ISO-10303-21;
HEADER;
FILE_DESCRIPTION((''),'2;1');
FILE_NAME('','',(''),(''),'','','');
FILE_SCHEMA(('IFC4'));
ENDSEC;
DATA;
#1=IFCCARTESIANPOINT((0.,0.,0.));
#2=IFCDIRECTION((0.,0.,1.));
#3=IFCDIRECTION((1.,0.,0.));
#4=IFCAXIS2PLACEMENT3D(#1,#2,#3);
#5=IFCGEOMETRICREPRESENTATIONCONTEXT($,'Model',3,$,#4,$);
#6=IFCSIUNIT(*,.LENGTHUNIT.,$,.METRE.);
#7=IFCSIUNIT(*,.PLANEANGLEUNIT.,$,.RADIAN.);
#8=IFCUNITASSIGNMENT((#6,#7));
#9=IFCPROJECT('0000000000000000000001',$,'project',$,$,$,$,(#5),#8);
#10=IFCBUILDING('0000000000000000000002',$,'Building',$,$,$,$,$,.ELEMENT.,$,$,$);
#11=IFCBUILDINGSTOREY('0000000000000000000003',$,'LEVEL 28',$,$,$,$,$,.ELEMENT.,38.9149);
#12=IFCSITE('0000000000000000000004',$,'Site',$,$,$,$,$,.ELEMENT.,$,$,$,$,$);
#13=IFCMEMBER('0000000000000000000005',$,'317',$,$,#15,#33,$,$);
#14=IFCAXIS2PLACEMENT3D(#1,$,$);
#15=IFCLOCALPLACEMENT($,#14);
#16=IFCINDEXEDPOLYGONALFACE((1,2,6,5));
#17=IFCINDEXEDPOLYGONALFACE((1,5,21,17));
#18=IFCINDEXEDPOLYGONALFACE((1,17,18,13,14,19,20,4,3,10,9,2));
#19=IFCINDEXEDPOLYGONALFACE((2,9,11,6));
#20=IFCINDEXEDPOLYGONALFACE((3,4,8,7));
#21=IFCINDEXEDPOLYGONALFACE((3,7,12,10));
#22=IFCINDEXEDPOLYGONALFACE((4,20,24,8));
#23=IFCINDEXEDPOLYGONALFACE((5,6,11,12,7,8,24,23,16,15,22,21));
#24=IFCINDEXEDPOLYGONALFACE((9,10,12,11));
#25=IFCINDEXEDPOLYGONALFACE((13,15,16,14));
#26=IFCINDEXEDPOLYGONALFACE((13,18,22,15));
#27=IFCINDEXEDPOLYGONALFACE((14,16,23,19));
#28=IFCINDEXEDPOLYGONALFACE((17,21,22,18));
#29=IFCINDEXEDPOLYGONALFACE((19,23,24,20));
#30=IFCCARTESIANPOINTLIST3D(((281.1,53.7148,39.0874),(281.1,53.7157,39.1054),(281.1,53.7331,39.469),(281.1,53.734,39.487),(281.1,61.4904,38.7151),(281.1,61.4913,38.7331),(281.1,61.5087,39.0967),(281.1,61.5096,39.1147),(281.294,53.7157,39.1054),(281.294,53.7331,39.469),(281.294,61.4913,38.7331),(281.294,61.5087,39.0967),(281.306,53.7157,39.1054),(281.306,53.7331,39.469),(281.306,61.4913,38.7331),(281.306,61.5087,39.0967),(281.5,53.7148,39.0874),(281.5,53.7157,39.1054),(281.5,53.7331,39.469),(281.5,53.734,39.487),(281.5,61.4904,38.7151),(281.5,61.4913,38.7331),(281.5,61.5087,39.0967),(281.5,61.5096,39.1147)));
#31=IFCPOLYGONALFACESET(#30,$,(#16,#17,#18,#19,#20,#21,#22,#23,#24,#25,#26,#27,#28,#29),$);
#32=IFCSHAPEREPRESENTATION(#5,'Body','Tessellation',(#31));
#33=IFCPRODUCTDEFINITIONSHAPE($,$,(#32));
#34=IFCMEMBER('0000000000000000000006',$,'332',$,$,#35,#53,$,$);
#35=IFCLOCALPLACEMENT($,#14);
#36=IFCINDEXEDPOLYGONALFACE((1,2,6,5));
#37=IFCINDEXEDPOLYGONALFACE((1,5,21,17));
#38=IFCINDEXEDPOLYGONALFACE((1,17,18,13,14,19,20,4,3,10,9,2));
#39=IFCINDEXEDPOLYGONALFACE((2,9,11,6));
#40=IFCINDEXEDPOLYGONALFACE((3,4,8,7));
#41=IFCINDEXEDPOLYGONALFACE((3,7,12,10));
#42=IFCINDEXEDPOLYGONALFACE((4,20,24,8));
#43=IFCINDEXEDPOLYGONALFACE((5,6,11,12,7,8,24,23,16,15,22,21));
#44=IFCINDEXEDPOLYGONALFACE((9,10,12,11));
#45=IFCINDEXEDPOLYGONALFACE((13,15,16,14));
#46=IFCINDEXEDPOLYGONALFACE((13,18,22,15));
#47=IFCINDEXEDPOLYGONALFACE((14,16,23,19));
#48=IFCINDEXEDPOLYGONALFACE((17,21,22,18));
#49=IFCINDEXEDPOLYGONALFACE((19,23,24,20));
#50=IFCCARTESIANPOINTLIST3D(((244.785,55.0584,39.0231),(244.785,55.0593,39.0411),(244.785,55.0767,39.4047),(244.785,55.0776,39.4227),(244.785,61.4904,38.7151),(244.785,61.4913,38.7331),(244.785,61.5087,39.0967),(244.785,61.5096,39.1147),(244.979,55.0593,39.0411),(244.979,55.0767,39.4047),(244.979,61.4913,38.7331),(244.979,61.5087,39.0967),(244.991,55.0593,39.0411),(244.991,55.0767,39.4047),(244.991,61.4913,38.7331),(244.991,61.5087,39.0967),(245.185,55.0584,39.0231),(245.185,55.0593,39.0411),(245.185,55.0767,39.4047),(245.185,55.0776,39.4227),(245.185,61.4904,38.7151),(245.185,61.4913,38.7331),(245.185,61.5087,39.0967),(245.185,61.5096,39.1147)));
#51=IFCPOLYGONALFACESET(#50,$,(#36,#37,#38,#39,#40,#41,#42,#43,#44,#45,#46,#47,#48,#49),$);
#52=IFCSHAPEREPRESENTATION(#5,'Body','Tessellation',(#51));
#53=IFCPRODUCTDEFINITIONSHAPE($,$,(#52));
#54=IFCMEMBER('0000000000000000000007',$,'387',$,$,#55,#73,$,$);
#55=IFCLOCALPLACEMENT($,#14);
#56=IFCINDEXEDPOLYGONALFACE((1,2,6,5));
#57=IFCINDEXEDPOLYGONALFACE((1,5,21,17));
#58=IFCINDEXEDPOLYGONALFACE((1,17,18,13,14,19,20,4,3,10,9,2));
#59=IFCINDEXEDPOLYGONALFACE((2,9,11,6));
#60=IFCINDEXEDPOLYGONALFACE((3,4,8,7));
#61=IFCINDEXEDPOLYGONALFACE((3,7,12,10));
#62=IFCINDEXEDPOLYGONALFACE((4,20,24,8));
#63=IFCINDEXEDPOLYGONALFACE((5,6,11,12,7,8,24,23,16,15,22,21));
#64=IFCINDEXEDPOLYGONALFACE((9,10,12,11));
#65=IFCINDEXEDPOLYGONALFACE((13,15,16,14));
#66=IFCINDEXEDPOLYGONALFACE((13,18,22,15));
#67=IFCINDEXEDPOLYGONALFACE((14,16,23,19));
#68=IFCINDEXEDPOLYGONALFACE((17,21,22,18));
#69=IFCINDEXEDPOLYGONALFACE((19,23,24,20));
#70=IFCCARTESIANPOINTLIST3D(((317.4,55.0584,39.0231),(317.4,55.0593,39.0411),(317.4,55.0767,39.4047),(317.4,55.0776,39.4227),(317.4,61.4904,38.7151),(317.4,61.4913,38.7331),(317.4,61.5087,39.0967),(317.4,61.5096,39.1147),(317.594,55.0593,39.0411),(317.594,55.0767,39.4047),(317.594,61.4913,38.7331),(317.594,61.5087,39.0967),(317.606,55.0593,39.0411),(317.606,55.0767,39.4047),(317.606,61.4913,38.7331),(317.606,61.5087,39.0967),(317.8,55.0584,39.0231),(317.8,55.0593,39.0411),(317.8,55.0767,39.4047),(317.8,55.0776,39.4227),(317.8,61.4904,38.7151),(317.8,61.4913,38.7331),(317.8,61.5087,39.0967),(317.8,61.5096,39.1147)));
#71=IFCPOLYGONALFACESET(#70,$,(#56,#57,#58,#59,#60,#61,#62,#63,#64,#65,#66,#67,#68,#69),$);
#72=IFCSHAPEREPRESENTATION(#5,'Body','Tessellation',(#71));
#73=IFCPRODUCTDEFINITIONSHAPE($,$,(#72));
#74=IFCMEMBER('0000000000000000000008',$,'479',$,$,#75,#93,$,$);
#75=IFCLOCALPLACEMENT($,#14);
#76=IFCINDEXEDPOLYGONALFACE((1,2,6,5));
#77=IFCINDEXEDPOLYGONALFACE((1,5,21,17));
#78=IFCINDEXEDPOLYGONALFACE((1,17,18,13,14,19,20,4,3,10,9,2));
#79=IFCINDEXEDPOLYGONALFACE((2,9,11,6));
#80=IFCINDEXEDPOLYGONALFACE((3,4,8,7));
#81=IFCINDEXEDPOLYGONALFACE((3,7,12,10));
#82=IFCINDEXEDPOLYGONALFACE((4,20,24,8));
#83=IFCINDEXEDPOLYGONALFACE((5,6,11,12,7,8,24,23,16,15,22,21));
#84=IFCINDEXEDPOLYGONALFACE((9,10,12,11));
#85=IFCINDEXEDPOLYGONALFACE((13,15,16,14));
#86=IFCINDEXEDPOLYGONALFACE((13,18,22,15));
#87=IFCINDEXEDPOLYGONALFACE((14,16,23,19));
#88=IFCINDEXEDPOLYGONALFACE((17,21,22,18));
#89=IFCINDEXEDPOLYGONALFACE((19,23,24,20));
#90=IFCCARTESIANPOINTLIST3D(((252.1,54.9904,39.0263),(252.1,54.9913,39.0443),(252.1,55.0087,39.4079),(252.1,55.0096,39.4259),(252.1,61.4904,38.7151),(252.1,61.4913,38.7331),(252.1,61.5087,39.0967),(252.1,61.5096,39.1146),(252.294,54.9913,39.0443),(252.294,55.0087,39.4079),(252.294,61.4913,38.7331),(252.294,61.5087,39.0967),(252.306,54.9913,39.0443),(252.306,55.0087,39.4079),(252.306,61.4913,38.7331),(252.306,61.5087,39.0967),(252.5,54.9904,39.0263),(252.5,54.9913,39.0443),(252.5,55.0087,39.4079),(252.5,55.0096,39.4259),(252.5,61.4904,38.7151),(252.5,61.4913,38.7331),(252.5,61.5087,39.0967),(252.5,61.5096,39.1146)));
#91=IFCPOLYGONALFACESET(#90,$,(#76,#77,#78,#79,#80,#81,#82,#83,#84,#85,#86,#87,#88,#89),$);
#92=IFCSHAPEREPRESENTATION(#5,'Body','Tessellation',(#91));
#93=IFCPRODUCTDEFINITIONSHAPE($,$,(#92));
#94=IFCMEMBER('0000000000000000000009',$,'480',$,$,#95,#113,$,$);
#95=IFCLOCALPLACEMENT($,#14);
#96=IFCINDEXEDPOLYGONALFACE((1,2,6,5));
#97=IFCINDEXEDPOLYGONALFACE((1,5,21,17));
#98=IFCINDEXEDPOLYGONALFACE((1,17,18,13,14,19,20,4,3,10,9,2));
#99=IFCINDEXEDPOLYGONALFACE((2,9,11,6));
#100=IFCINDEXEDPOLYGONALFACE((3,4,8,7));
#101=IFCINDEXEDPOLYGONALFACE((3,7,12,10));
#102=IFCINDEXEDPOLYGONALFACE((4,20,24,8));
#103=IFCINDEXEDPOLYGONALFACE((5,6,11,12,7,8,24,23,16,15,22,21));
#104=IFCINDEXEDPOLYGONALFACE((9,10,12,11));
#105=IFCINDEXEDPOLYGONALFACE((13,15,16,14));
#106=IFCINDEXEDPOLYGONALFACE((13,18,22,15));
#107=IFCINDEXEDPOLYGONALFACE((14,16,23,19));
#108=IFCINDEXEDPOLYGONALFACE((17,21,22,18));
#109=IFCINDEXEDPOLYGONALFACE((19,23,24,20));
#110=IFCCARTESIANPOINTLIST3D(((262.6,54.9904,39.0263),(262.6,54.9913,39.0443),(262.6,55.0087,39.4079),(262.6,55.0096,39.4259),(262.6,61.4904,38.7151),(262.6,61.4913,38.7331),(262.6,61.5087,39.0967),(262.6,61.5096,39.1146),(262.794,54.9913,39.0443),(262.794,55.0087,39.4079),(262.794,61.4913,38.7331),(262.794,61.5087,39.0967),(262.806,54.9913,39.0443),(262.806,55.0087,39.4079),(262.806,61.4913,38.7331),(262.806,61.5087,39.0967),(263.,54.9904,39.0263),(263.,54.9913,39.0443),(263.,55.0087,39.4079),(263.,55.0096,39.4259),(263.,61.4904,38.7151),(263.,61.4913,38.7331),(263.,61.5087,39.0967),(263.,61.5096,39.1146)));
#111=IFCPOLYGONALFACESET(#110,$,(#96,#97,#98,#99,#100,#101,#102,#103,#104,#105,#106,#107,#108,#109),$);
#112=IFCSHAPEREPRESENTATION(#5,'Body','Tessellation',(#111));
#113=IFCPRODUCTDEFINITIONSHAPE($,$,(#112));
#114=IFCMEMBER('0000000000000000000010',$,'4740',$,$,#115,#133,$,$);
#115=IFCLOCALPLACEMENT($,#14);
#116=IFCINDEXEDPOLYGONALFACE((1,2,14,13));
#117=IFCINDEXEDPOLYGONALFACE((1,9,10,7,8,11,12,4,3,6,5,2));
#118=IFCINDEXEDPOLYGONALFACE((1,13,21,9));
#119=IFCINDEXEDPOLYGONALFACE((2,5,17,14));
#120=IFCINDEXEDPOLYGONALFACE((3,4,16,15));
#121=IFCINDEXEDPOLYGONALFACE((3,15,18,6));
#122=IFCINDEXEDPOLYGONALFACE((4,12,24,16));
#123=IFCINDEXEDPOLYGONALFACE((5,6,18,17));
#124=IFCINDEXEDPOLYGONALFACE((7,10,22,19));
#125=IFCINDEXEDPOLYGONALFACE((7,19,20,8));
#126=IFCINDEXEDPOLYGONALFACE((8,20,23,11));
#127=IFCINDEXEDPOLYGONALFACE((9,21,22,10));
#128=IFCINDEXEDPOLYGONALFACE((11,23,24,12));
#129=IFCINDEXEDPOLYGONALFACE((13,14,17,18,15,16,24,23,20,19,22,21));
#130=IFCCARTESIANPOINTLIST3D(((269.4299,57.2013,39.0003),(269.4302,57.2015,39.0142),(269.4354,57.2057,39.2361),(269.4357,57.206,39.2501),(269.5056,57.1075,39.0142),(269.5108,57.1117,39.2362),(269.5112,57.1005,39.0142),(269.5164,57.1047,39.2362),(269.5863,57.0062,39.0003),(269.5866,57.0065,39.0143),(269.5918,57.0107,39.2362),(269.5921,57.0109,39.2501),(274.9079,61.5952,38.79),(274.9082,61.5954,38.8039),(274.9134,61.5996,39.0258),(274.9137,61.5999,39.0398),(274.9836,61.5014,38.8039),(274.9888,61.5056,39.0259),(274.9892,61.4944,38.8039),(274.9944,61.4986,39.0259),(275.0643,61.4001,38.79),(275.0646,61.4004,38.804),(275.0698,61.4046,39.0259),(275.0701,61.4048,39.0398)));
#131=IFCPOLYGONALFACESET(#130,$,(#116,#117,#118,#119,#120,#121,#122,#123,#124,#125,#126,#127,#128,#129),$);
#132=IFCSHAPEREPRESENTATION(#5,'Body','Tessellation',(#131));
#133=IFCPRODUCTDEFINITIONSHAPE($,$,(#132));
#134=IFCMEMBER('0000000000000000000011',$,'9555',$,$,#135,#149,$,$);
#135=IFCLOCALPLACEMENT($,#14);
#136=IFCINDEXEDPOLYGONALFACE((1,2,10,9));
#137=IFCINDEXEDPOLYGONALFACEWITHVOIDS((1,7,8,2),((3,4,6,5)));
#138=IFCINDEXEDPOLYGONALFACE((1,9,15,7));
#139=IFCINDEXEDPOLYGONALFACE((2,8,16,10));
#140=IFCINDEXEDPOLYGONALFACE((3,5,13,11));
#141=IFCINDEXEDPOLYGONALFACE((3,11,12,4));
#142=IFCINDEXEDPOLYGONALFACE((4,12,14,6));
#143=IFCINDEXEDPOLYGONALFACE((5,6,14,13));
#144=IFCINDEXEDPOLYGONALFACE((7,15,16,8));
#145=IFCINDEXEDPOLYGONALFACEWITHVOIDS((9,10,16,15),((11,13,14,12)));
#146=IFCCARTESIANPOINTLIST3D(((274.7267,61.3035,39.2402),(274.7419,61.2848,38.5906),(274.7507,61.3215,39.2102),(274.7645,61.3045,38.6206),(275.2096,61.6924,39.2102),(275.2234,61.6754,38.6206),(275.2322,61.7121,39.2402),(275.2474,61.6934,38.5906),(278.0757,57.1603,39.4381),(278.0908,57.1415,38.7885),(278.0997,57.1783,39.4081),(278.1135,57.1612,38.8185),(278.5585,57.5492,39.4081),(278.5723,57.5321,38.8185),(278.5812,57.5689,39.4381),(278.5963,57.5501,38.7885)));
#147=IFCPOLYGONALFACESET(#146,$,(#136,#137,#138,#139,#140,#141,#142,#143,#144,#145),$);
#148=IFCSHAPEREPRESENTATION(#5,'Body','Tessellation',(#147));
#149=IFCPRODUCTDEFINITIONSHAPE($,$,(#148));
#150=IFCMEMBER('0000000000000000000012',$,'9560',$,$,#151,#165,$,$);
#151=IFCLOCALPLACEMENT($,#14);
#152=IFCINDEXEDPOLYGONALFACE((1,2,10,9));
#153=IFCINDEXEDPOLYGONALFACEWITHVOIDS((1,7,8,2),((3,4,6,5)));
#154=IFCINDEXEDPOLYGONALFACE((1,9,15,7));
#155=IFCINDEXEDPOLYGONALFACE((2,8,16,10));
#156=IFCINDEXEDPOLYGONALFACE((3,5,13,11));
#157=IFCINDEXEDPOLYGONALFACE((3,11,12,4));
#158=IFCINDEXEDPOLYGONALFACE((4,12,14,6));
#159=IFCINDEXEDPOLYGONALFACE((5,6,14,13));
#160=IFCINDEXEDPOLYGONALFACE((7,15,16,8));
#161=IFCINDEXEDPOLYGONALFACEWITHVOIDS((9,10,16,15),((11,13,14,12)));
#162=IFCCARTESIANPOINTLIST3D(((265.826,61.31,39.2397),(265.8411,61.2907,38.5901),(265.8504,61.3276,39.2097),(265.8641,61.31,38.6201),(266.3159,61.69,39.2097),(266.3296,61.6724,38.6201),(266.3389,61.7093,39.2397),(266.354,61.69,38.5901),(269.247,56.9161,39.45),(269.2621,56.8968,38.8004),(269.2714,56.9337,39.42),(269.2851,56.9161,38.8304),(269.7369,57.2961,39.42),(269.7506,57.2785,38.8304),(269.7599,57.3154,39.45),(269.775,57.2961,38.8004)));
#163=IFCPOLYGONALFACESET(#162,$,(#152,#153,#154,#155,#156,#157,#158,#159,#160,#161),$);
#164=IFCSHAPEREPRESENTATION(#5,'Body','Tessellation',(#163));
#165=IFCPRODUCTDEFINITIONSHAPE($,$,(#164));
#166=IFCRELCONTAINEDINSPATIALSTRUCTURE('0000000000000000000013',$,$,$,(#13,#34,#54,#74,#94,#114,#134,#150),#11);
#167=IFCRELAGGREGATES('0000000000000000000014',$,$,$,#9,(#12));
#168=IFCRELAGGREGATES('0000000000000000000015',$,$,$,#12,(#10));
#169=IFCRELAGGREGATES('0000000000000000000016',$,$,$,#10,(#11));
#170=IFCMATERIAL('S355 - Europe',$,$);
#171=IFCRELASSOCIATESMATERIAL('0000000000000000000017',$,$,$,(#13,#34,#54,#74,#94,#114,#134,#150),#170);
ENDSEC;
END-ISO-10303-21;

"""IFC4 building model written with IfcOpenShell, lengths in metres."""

from ifc_helpers import new_model, si_unit, frame, origin_with_axes, origin_2d_with_axis, place, context, project, spatial, hollow_rectangle, i_section, extrude, material, material_profile, profile_set, profile_usage, element, save


model = new_model("IFC4")

# Units and contexts
model_context = context("Model", 3, world=origin_with_axes())
ifc_project = project(units=[si_unit("LENGTHUNIT", "METRE"), si_unit("PLANEANGLEUNIT", "RADIAN")], contexts=[model_context])

# Site, building, storey
site = spatial("IfcSite", under=ifc_project, Name="Site", CompositionType="ELEMENT")
building = spatial("IfcBuilding", under=site, Name="Building", CompositionType="ELEMENT")
storey = spatial("IfcBuildingStorey", under=building, Name="LEVEL 28", CompositionType="ELEMENT", Elevation=38.9149)

# Shared definitions
ifc_material = material(Name="S355 - Europe")

# Members
ifc_material_profile_1 = material_profile(ifc_material, i_section(OverallWidth=0.4, OverallDepth=0.4, WebThickness=0.012, FlangeThickness=0.018, at=origin_2d_with_axis()))
ifc_profile_set_1 = profile_set([ifc_material_profile_1])
ifc_profile_usage_1 = profile_usage(ifc_profile_set_1, cardinal=10)
member_1_placement = place(None, frame((281.3, 61.5, 38.9149), z_axis=(0.0, -0.998856, 0.047828), x_axis=(1.0, 0.0, 0.0)))
element("IfcMember", 1, at=member_1_placement, inside=storey, material=ifc_profile_usage_1, Name="317", context=model_context, shape_type="SweptSolid", body=[
    extrude(i_section(OverallWidth=0.4, OverallDepth=0.4, WebThickness=0.012, FlangeThickness=0.018, at=origin_2d_with_axis()), origin_with_axes(), (0.0, 0.0, 1.0), 7.7845),
])
ifc_material_profile_2 = material_profile(ifc_material, i_section(OverallWidth=0.4, OverallDepth=0.4, WebThickness=0.012, FlangeThickness=0.018, at=origin_2d_with_axis()))
ifc_profile_set_2 = profile_set([ifc_material_profile_2])
ifc_profile_usage_2 = profile_usage(ifc_profile_set_2, cardinal=10)
member_2_placement = place(None, frame((244.985, 61.5, 38.9149), z_axis=(0.0, -0.998856, 0.047828), x_axis=(1.0, 0.0, 0.0)))
element("IfcMember", 2, at=member_2_placement, inside=storey, material=ifc_profile_usage_2, Name="332", context=model_context, shape_type="SweptSolid", body=[
    extrude(i_section(OverallWidth=0.4, OverallDepth=0.4, WebThickness=0.012, FlangeThickness=0.018, at=origin_2d_with_axis()), origin_with_axes(), (0.0, 0.0, 1.0), 6.4394),
])
ifc_material_profile_3 = material_profile(ifc_material, i_section(OverallWidth=0.4, OverallDepth=0.4, WebThickness=0.012, FlangeThickness=0.018, at=origin_2d_with_axis()))
ifc_profile_set_3 = profile_set([ifc_material_profile_3])
ifc_profile_usage_3 = profile_usage(ifc_profile_set_3, cardinal=10)
member_3_placement = place(None, frame((317.6, 61.5, 38.9149), z_axis=(0.0, -0.998856, 0.047828), x_axis=(1.0, 0.0, 0.0)))
element("IfcMember", 3, at=member_3_placement, inside=storey, material=ifc_profile_usage_3, Name="387", context=model_context, shape_type="SweptSolid", body=[
    extrude(i_section(OverallWidth=0.4, OverallDepth=0.4, WebThickness=0.012, FlangeThickness=0.018, at=origin_2d_with_axis()), origin_with_axes(), (0.0, 0.0, 1.0), 6.4394),
])
ifc_material_profile_4 = material_profile(ifc_material, i_section(OverallWidth=0.4, OverallDepth=0.4, WebThickness=0.012, FlangeThickness=0.018, at=origin_2d_with_axis()))
ifc_profile_set_4 = profile_set([ifc_material_profile_4])
ifc_profile_usage_4 = profile_usage(ifc_profile_set_4, cardinal=10)
member_4_placement = place(None, frame((252.3, 55.0, 39.2261), z_axis=(0.0, 0.998856, -0.047828), x_axis=(-1.0, 0.0, 0.0)))
element("IfcMember", 4, at=member_4_placement, inside=storey, material=ifc_profile_usage_4, Name="479", context=model_context, shape_type="SweptSolid", body=[
    extrude(i_section(OverallWidth=0.4, OverallDepth=0.4, WebThickness=0.012, FlangeThickness=0.018, at=origin_2d_with_axis()), origin_with_axes(), (0.0, 0.0, 1.0), 6.5074),
])
ifc_material_profile_5 = material_profile(ifc_material, i_section(OverallWidth=0.4, OverallDepth=0.4, WebThickness=0.012, FlangeThickness=0.018, at=origin_2d_with_axis()))
ifc_profile_set_5 = profile_set([ifc_material_profile_5])
ifc_profile_usage_5 = profile_usage(ifc_profile_set_5, cardinal=10)
member_5_placement = place(None, frame((262.8, 55.0, 39.2261), z_axis=(0.0, 0.998856, -0.047828), x_axis=(-1.0, 0.0, 0.0)))
element("IfcMember", 5, at=member_5_placement, inside=storey, material=ifc_profile_usage_5, Name="480", context=model_context, shape_type="SweptSolid", body=[
    extrude(i_section(OverallWidth=0.4, OverallDepth=0.4, WebThickness=0.012, FlangeThickness=0.018, at=origin_2d_with_axis()), origin_with_axes(), (0.0, 0.0, 1.0), 6.5074),
])
ifc_material_profile_6 = material_profile(ifc_material, i_section(OverallWidth=0.25, OverallDepth=0.25, WebThickness=0.009, FlangeThickness=0.014, at=origin_2d_with_axis()))
ifc_profile_set_6 = profile_set([ifc_material_profile_6])
ifc_profile_usage_6 = profile_usage(ifc_profile_set_6, cardinal=10)
member_6_placement = place(None, frame((269.511, 57.1061, 39.1252), z_axis=(0.77972, 0.625413, -0.029933), x_axis=(-0.626214, 0.779651, 0.0)))
element("IfcMember", 6, at=member_6_placement, inside=storey, material=ifc_profile_usage_6, Name="4740", context=model_context, shape_type="SweptSolid", body=[
    extrude(i_section(OverallWidth=0.25, OverallDepth=0.25, WebThickness=0.009, FlangeThickness=0.014, at=origin_2d_with_axis()), origin_with_axes(), (0.0, 0.0, 1.0), 7.0256),
])
ifc_material_profile_7 = material_profile(ifc_material, hollow_rectangle(XDim=0.65, YDim=0.65, WallThickness=0.03, at=origin_2d_with_axis()))
ifc_profile_set_7 = profile_set([ifc_material_profile_7])
ifc_profile_usage_7 = profile_usage(ifc_profile_set_7, cardinal=10)
member_7_placement = place(None, frame((278.336, 57.3552, 39.1133), z_axis=(-0.628186, 0.777177, -0.03712), x_axis=(-0.777987, -0.62828, 0.0)))
element("IfcMember", 7, at=member_7_placement, inside=storey, material=ifc_profile_usage_7, Name="9555", context=model_context, shape_type="SweptSolid", body=[
    extrude(hollow_rectangle(XDim=0.65, YDim=0.65, WallThickness=0.03, at=origin_2d_with_axis()), origin_with_axes(), (0.0, 0.0, 1.0), 5.3311),
])
ifc_material_profile_8 = material_profile(ifc_material, hollow_rectangle(XDim=0.65, YDim=0.65, WallThickness=0.03, at=origin_2d_with_axis()))
ifc_profile_set_8 = profile_set([ifc_material_profile_8])
ifc_profile_usage_8 = profile_usage(ifc_profile_set_8, cardinal=10)
member_8_placement = place(None, frame((266.09, 61.5, 38.9149), z_axis=(0.613897, -0.788484, 0.037738), x_axis=(0.789418, 0.613857, 0.0)))
element("IfcMember", 8, at=member_8_placement, inside=storey, material=ifc_profile_usage_8, Name="9560", context=model_context, shape_type="SweptSolid", body=[
    extrude(hollow_rectangle(XDim=0.65, YDim=0.65, WallThickness=0.03, at=origin_2d_with_axis()), origin_with_axes(), (0.0, 0.0, 1.0), 5.5726),
])

save(model, "model.ifc")
